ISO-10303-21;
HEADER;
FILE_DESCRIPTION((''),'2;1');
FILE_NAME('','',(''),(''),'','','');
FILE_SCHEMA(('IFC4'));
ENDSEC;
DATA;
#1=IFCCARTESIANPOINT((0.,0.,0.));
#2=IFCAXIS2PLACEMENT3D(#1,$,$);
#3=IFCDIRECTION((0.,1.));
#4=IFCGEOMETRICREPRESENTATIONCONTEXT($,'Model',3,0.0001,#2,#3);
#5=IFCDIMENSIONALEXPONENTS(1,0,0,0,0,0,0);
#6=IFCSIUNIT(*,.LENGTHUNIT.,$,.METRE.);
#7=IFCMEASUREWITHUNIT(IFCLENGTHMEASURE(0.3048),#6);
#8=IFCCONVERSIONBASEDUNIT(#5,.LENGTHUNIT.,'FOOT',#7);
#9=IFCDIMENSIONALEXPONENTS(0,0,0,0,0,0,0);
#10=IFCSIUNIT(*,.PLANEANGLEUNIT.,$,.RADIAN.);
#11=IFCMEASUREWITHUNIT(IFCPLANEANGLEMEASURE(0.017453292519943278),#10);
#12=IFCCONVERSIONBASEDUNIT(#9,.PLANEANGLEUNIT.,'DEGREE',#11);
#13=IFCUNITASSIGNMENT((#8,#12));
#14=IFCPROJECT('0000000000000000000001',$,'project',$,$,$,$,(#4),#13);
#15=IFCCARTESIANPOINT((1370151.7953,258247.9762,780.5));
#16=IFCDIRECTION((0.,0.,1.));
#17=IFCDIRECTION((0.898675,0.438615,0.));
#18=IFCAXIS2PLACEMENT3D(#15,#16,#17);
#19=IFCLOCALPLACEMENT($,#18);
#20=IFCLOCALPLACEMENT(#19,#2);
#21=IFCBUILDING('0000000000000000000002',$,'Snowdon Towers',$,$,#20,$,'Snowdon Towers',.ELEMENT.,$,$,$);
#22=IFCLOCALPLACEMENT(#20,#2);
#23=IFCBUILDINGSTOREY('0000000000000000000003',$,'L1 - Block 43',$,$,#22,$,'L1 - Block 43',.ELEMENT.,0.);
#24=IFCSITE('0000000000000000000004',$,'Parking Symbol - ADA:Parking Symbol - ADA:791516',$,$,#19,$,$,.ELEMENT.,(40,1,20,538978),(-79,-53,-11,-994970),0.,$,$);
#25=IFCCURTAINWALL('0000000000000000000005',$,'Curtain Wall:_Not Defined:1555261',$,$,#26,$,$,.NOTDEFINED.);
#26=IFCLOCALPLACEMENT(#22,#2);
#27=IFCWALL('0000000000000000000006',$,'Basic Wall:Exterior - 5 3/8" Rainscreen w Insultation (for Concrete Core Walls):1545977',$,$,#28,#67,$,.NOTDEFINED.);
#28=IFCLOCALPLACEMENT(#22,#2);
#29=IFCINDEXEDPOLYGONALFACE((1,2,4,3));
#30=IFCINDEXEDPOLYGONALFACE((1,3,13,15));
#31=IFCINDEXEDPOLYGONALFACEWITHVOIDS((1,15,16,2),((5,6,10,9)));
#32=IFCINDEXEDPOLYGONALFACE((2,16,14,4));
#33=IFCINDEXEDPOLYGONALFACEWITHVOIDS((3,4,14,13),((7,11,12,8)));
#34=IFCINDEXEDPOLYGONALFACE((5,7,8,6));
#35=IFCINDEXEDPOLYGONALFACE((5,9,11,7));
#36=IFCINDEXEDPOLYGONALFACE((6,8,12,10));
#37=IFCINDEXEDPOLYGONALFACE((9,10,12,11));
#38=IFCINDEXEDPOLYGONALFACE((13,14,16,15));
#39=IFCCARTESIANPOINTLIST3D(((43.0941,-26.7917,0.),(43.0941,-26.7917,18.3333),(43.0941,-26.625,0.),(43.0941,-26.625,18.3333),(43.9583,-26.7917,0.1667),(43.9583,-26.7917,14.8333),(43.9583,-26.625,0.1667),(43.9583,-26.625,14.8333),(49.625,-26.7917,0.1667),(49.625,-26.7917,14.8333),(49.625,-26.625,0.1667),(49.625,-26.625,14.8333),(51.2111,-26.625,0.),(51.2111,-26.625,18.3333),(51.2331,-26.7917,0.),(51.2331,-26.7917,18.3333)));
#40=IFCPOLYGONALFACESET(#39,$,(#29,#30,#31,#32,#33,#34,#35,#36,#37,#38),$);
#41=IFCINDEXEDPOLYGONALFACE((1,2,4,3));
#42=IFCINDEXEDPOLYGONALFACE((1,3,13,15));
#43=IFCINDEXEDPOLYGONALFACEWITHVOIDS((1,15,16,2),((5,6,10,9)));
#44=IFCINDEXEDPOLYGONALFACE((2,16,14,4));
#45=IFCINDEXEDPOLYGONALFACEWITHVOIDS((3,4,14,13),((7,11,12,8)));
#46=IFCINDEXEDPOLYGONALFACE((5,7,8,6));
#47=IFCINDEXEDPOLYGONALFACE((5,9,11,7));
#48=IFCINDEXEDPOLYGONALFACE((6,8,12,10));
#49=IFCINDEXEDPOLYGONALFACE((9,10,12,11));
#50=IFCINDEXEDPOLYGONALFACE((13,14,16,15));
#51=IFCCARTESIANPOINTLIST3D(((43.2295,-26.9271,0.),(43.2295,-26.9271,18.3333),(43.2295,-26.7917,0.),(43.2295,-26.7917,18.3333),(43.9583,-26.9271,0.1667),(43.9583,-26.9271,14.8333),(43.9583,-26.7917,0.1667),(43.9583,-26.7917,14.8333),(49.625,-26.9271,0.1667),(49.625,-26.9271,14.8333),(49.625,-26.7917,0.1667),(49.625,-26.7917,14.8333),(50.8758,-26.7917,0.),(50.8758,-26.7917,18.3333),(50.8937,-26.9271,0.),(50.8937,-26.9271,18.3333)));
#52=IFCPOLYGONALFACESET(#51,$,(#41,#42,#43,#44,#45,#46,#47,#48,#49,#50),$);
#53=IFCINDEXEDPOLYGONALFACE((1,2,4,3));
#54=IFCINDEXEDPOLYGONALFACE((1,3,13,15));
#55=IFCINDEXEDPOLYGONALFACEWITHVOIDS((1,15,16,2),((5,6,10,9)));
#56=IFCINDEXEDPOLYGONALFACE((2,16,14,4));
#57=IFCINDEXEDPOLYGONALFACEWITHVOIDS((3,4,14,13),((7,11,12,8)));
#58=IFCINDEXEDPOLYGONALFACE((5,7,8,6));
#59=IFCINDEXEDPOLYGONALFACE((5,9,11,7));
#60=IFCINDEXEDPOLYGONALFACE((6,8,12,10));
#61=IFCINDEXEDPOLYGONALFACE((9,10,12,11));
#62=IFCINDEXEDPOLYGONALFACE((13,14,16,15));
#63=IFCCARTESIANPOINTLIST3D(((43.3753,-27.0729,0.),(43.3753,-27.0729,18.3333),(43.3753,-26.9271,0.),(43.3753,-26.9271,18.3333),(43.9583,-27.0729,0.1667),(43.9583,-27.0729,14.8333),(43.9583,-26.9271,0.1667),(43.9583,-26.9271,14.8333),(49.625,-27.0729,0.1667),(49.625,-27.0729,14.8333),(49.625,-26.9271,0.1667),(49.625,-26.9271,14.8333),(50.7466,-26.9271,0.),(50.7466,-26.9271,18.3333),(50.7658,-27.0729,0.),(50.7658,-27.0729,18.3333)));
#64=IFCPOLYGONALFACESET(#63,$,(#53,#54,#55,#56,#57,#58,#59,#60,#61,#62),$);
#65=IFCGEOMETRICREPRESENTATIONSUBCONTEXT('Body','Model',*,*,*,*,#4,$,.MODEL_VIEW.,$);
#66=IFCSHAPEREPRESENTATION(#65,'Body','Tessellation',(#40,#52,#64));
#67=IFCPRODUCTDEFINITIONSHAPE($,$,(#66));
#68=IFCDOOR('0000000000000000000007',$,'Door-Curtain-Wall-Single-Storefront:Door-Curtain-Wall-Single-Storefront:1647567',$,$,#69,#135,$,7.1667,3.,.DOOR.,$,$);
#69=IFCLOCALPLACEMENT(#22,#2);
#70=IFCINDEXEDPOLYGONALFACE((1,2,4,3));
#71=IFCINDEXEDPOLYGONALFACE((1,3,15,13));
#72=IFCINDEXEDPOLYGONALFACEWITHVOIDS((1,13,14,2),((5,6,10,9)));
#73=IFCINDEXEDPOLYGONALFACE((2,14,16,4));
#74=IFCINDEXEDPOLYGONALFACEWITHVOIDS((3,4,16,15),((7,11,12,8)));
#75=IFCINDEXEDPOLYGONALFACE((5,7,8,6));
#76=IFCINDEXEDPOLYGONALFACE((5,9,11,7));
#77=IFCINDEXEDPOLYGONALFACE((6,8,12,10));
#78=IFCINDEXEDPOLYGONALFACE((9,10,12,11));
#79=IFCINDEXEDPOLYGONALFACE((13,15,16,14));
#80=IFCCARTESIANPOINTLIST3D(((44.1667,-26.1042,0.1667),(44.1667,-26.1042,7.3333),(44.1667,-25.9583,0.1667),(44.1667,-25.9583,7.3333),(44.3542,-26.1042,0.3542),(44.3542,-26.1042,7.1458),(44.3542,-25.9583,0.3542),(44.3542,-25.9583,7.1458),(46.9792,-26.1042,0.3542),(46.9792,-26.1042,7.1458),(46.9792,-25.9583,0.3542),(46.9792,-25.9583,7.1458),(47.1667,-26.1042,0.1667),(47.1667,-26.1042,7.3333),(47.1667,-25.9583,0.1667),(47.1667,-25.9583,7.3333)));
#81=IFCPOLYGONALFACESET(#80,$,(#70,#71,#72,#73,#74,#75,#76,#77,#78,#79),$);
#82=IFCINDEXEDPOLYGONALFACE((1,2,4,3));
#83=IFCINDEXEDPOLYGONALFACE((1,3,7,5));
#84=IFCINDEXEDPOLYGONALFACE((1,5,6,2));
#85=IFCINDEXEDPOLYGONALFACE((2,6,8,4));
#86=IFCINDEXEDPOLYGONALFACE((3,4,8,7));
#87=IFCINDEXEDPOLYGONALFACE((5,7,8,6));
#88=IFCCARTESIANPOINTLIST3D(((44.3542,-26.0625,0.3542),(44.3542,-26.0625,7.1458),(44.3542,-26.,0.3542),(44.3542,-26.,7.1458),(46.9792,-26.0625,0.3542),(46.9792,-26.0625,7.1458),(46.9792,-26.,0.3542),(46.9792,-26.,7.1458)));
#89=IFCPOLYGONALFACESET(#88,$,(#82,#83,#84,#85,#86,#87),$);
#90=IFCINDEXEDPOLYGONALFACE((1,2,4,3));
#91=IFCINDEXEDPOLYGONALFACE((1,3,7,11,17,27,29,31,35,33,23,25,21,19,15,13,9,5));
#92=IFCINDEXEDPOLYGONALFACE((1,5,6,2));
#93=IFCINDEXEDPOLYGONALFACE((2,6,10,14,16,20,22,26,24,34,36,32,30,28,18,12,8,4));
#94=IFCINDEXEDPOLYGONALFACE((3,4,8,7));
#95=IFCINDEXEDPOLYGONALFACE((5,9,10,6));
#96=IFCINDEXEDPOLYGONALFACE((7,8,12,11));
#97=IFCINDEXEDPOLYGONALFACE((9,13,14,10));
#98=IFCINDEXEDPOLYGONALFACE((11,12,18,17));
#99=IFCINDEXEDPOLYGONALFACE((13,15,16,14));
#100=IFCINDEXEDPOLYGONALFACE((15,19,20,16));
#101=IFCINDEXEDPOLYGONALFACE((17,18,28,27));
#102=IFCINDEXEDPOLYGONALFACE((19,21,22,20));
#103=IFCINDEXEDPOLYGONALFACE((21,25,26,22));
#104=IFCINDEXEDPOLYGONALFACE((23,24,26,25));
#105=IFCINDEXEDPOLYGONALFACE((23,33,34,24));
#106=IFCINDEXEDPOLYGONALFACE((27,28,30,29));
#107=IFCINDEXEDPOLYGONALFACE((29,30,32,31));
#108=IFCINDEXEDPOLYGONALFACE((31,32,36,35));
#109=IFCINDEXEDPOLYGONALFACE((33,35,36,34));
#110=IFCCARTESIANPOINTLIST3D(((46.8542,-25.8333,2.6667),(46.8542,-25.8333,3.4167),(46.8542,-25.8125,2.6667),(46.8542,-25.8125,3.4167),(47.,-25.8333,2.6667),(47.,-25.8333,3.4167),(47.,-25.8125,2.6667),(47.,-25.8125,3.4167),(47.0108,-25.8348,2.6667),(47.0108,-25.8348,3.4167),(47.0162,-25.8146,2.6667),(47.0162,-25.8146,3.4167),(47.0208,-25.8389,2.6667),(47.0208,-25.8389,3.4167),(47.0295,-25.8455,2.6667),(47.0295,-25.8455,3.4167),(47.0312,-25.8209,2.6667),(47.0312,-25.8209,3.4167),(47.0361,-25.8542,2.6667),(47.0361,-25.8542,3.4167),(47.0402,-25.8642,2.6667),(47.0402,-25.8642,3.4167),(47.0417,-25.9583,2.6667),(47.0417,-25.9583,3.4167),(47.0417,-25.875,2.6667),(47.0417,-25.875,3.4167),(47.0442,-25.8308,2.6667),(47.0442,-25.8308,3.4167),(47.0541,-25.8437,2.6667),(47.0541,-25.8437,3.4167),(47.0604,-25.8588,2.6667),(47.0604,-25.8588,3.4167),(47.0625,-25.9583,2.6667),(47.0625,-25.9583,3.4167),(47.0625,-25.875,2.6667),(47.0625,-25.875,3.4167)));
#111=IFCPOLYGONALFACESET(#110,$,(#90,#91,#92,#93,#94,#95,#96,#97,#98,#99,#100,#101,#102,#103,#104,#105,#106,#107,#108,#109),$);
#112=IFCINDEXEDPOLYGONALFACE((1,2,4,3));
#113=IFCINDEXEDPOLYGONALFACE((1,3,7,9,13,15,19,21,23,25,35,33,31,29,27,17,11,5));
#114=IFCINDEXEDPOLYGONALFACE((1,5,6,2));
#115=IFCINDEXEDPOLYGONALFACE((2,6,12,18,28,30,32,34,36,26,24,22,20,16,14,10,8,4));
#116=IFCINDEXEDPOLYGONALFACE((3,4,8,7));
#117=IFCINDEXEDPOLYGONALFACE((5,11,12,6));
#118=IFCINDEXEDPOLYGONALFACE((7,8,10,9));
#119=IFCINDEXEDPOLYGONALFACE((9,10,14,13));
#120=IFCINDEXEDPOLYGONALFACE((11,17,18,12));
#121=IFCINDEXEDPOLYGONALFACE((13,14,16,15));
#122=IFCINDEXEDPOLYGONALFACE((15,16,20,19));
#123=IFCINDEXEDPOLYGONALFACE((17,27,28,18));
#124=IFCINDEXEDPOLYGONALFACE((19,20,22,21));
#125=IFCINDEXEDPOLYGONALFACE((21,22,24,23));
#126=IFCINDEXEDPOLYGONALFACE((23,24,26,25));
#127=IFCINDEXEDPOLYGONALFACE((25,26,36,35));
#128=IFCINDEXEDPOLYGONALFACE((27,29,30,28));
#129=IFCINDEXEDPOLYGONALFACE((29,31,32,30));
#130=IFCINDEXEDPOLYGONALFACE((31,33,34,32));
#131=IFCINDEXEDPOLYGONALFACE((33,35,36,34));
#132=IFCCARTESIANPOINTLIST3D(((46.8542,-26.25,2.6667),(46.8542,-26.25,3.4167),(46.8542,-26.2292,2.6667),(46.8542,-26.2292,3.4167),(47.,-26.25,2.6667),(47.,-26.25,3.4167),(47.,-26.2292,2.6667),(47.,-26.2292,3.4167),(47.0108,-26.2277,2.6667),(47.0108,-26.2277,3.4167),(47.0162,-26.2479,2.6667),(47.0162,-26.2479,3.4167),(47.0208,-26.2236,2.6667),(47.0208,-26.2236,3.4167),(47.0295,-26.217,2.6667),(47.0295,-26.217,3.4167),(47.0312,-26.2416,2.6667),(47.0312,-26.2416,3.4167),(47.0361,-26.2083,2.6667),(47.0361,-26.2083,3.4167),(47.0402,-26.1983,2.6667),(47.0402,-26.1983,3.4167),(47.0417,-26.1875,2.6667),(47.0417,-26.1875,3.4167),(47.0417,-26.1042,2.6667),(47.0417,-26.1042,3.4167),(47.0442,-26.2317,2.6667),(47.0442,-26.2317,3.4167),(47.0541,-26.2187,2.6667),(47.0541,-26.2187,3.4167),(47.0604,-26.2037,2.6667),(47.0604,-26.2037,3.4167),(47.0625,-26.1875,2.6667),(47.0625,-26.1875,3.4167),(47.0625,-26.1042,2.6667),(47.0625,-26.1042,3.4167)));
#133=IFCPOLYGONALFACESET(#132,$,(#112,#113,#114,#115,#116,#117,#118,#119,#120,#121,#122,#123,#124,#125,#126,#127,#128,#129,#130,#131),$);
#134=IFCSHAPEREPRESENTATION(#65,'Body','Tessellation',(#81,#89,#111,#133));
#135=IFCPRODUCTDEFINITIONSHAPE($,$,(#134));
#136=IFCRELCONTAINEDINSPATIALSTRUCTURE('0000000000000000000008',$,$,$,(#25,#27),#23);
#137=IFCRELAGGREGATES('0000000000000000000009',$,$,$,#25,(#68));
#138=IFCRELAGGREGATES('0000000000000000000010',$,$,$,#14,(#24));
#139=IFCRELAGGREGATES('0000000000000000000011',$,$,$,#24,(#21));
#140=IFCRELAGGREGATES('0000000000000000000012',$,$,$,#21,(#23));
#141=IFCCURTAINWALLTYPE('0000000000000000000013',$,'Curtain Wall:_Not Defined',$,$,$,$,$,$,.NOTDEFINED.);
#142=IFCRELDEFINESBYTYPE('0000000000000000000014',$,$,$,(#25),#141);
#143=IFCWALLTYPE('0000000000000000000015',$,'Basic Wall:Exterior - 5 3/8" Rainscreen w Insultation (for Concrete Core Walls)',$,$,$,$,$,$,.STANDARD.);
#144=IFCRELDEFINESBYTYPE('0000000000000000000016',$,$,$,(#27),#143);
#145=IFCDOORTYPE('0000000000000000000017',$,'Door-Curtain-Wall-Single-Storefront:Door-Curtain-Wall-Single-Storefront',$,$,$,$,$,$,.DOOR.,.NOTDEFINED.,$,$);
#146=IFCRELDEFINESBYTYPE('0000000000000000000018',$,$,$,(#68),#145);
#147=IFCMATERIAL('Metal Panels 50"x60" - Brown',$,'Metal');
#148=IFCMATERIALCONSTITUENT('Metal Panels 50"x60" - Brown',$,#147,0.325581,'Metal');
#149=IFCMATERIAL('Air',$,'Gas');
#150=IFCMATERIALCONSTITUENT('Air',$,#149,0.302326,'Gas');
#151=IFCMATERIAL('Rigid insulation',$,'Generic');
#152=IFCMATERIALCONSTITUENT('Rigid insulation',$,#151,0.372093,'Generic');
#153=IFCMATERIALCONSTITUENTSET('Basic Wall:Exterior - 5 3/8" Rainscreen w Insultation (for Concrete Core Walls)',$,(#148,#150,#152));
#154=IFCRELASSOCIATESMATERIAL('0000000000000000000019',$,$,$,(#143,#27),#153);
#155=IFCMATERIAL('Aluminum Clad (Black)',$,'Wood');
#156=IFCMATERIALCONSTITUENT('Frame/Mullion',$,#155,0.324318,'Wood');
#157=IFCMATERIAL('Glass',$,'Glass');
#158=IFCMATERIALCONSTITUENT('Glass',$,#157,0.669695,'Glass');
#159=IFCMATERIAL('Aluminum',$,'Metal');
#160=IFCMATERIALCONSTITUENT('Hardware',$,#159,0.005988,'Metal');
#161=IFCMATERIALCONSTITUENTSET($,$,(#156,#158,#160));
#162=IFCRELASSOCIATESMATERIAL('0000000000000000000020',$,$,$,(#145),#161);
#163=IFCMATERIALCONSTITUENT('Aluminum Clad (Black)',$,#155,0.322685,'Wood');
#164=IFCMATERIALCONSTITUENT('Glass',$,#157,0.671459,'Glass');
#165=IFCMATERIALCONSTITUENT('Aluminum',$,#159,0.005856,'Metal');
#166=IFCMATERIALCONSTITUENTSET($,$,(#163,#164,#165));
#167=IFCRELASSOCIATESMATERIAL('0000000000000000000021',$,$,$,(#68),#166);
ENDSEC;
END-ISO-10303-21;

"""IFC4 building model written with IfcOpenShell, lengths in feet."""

from ifc_helpers import new_model, entity, si_unit, converted_unit, direction, frame, origin, place, context, subcontext, project, spatial, line, arc, indexed_curve, outline, extrude, source, transform, mapped, material, constituent, constituent_set, type_object, type_shapes, element, aggregate, save


model = new_model("IFC4")

# Units and contexts
model_context = context("Model", 3, precision=0.0001, world=origin(), true_north=direction((0.0, 1.0)))
body_context = subcontext(model_context, "Body", "Model", "MODEL_VIEW")
ifc_project = project(units=[converted_unit("LENGTHUNIT", "FOOT", entity("IfcLengthMeasure", 0.3048), si_unit("LENGTHUNIT", "METRE"), dimensions=[1, 0, 0, 0, 0, 0, 0]), converted_unit("PLANEANGLEUNIT", "DEGREE", entity("IfcPlaneAngleMeasure", 0.017453292519943278), si_unit("PLANEANGLEUNIT", "RADIAN"), dimensions=[0, 0, 0, 0, 0, 0, 0])], contexts=[model_context])

# Site, building, storey
site_placement = place(None, frame((1370151.7953, 258247.9762, 780.5), z_axis=(0.0, 0.0, 1.0), x_axis=(0.898675, 0.438615, 0.0)))
site = spatial("IfcSite", under=ifc_project, at=site_placement, Name="Parking Symbol - ADA:Parking Symbol - ADA:791516", CompositionType="ELEMENT", RefLatitude=(40, 1, 20, 538978), RefLongitude=(-79, -53, -11, -994970), RefElevation=0.0)
building_placement = place(site_placement, origin())
building = spatial("IfcBuilding", under=site, at=building_placement, Name="Snowdon Towers", LongName="Snowdon Towers", CompositionType="ELEMENT")
storey_placement = place(building_placement, origin())
storey = spatial("IfcBuildingStorey", under=building, at=storey_placement, Name="L1 - Block 43", LongName="L1 - Block 43", CompositionType="ELEMENT", Elevation=0.0)

# Curtain wall
curtain_wall_type = type_object("IfcCurtainWallType", Name="Curtain Wall:_Not Defined", PredefinedType="NOTDEFINED")
curtain_wall_1_placement = place(storey_placement, origin())
curtain_wall_1 = element("IfcCurtainWall", 1, at=curtain_wall_1_placement, inside=storey, type_object=curtain_wall_type, Name="Curtain Wall:_Not Defined:1555261", PredefinedType="NOTDEFINED")
ifc_material_1 = material(Name="Aluminum", Category="Metal")

# Shared definitions
ifc_material_2 = material(Name="Glass", Category="Glass")

# Wall, openings
ifc_material_3 = material(Name="Metal Panels 50\"x60\" - Brown", Category="Metal")
ifc_constituent_1 = constituent(ifc_material_3, Name="Metal Panels 50\"x60\" - Brown", Category="Metal", fraction=0.325581)
ifc_material_4 = material(Name="Air", Category="Gas")
ifc_constituent_2 = constituent(ifc_material_4, Name="Air", Category="Gas", fraction=0.302326)
ifc_material_5 = material(Name="Rigid insulation", Category="Generic")
ifc_constituent_3 = constituent(ifc_material_5, Name="Rigid insulation", Category="Generic", fraction=0.372093)
ifc_constituent_set_1 = constituent_set(constituents=[ifc_constituent_1, ifc_constituent_2, ifc_constituent_3], Name="Basic Wall:Exterior - 5 3/8\" Rainscreen w Insultation (for Concrete Core Walls)")
wall_type_1 = type_object("IfcWallType", Name="Basic Wall:Exterior - 5 3/8\" Rainscreen w Insultation (for Concrete Core Walls)", PredefinedType="STANDARD", material=ifc_constituent_set_1)
wall_1_placement = place(storey_placement, frame((43.3753, -26.849, 0.0)))
wall_1 = element("IfcWall", 2, at=wall_1_placement, inside=storey, type_object=wall_type_1, material=ifc_constituent_set_1, Name="Basic Wall:Exterior - 5 3/8\" Rainscreen w Insultation (for Concrete Core Walls):1545977", PredefinedType="NOTDEFINED", context=body_context, shape_type="SweptSolid", body=[
    extrude(outline(indexed_curve([(-0.0833, -4.064), (0.0833, -4.064), (0.0833, 4.075), (-0.0833, 4.053), (-0.0833, -4.064)], self_intersect=False)), frame((3.7828, 0.1406, 0.0), z_axis=(0.0, 0.0, 1.0), x_axis=(0.0, -1.0, 0.0)), (0.0, 0.0, 1.0), 18.3333),
    extrude(outline(indexed_curve([(-0.0677, -3.8276), (0.0677, -3.8276), (0.0677, 3.8365), (-0.0677, 3.8187), (-0.0677, -3.8276)], self_intersect=False)), frame((3.6818, -0.0104, 0.0), z_axis=(0.0, 0.0, 1.0), x_axis=(0.0, -1.0, 0.0)), (0.0, 0.0, 1.0), 18.3333),
    extrude(outline(indexed_curve([(-0.0729, -3.6904), (0.0729, -3.6904), (0.0729, 3.7), (-0.0729, 3.6808), (-0.0729, -3.6904)], self_intersect=False)), frame((3.6904, -0.151, 0.0), z_axis=(0.0, 0.0, 1.0), x_axis=(0.0, -1.0, 0.0)), (0.0, 0.0, 1.0), 18.3333),
])
opening_1_placement = place(storey_placement, frame((43.3753, -26.849, 0.0)))
element("IfcOpeningElement", 3, at=opening_1_placement, cuts=wall_1, PredefinedType="OPENING", context=body_context, shape_type="SweptSolid", body=[
    extrude(outline(indexed_curve([(-7.3333, -2.8333), (7.3333, -2.8333), (7.3333, 2.8333), (-7.3333, 2.8333), (-7.3333, -2.8333)], self_intersect=False)), frame((3.4164, -0.224, 7.5), z_axis=(0.0, 1.0, 0.0), x_axis=(0.0, 0.0, -1.0)), (0.0, 0.0, 1.0), 0.1458),
])
opening_2_placement = place(storey_placement, frame((43.3753, -26.849, 0.0)))
element("IfcOpeningElement", 4, at=opening_2_placement, cuts=wall_1, PredefinedType="OPENING", context=body_context, shape_type="SweptSolid", body=[
    extrude(outline(indexed_curve([(-7.3333, -2.8333), (7.3333, -2.8333), (7.3333, 2.8333), (-7.3333, 2.8333), (-7.3333, -2.8333)], self_intersect=False)), frame((3.4164, -0.0781, 7.5), z_axis=(0.0, 1.0, 0.0), x_axis=(0.0, 0.0, -1.0)), (0.0, 0.0, 1.0), 0.1354),
])
opening_3_placement = place(storey_placement, frame((43.3753, -26.849, 0.0)))
element("IfcOpeningElement", 5, at=opening_3_placement, cuts=wall_1, PredefinedType="OPENING", context=body_context, shape_type="SweptSolid", body=[
    extrude(outline(indexed_curve([(-7.3333, -2.8333), (7.3333, -2.8333), (7.3333, 2.8333), (-7.3333, 2.8333), (-7.3333, -2.8333)], self_intersect=False)), frame((3.4164, 0.224, 7.5), z_axis=(0.0, -1.0, 0.0), x_axis=(0.0, 0.0, 1.0)), (0.0, 0.0, 1.0), 0.1667),
])
opening_4_placement = place(wall_1_placement, origin())
element("IfcOpeningElement", 6, at=opening_4_placement, cuts=wall_1, PredefinedType="OPENING", context=body_context, shape_type="SweptSolid", body=[
    extrude(outline(indexed_curve([(-2.8333, -7.3333), (2.8333, -7.3333), (2.8333, 7.3333), (-2.8333, 7.3333), (-2.8333, -7.3333)], self_intersect=False)), frame((3.4164, -0.724, 7.5), z_axis=(0.0, 1.0, 0.0), x_axis=(-1.0, 0.0, 0.0)), (0.0, 0.0, 1.0), 1.4479),
])

# Door
ifc_material_6 = material(Name="Aluminum Clad (Black)", Category="Wood")
ifc_constituent_4 = constituent(ifc_material_6, Name="Aluminum Clad (Black)", Category="Wood", fraction=0.322685)
ifc_constituent_5 = constituent(ifc_material_2, Name="Glass", Category="Glass", fraction=0.671459)
ifc_constituent_6 = constituent(ifc_material_1, Name="Aluminum", Category="Metal", fraction=0.005856)
ifc_constituent_set_2 = constituent_set(constituents=[ifc_constituent_4, ifc_constituent_5, ifc_constituent_6])
ifc_constituent_7 = constituent(ifc_material_6, Name="Frame/Mullion", Category="Wood", fraction=0.324318)
ifc_constituent_8 = constituent(ifc_material_2, Name="Glass", Category="Glass", fraction=0.669695)
ifc_constituent_9 = constituent(ifc_material_1, Name="Hardware", Category="Metal", fraction=0.005988)
ifc_constituent_set_3 = constituent_set(constituents=[ifc_constituent_7, ifc_constituent_8, ifc_constituent_9])
door_type = type_object("IfcDoorType", Name="Door-Curtain-Wall-Single-Storefront:Door-Curtain-Wall-Single-Storefront", OperationType="NOTDEFINED", PredefinedType="DOOR", material=ifc_constituent_set_3)
shared_shape_1 = source(origin(), body_context, "Body", "SweptSolid", [
    extrude(outline(indexed_curve([(-3.5833, -1.5), (3.5833, -1.5), (3.5833, 1.5), (-3.5833, 1.5), (-3.5833, -1.5)], self_intersect=False), holes=[indexed_curve([(-3.3958, 1.3125), (3.3958, 1.3125), (3.3958, -1.3125), (-3.3958, -1.3125), (-3.3958, 1.3125)], self_intersect=False)]), frame((0.0, 0.1875, 3.5833), z_axis=(0.0, -1.0, 0.0), x_axis=(0.0, 0.0, -1.0)), (0.0, 0.0, 1.0), 0.1458),
    extrude(outline(indexed_curve([(-1.3125, -0.0312), (1.3125, -0.0312), (1.3125, 0.0312), (-1.3125, 0.0312), (-1.3125, -0.0312)], self_intersect=False)), frame((0.0, 0.1146, 0.1875)), (0.0, 0.0, 1.0), 6.7917),
    extrude(outline(indexed_curve([(0.0729, -0.0052), (0.0546, 0.039), (0.0104, 0.0573), (-0.1354, 0.0573), (-0.1354, 0.0365), (0.0104, 0.0365), (0.0399, 0.0243), (0.0521, -0.0052), (0.0521, -0.0885), (0.0729, -0.0885)], segments=[arc(1, 2, 3), line(3, 4, 5, 6), arc(6, 7, 8), line(8, 9, 10, 1)], self_intersect=False)), frame((-1.3229, -0.0469, 2.5), z_axis=(0.0, 0.0, 1.0), x_axis=(-1.0, 0.0, 0.0)), (0.0, 0.0, 1.0), 0.75),
    extrude(outline(indexed_curve([(0.0052, -0.0729), (0.0885, -0.0729), (0.0885, -0.0521), (0.0052, -0.0521), (-0.0243, -0.0399), (-0.0365, -0.0104), (-0.0365, 0.1354), (-0.0573, 0.1354), (-0.0573, -0.0104), (-0.039, -0.0546)], segments=[line(1, 2, 3, 4), arc(4, 5, 6), line(6, 7, 8, 9), arc(9, 10, 1)], self_intersect=False)), frame((-1.3229, 0.276, 2.5), z_axis=(0.0, 0.0, 1.0), x_axis=(0.0, -1.0, 0.0)), (0.0, 0.0, 1.0), 0.75),
])
type_shapes(door_type, [shared_shape_1])
door_placement = place(curtain_wall_1_placement, frame((45.6667, -25.9167, 0.1667), z_axis=(0.0, 0.0, 1.0), x_axis=(-1.0, 0.0, 0.0)))
door = element("IfcDoor", 7, at=door_placement, type_object=door_type, material=ifc_constituent_set_2, Name="Door-Curtain-Wall-Single-Storefront:Door-Curtain-Wall-Single-Storefront:1647567", OverallHeight=7.1667, OverallWidth=3.0, PredefinedType="DOOR", context=body_context, shape_type="MappedRepresentation", body=[
    mapped(shared_shape_1, transform((0.0, 0.0, 0.0), scale=1.0)),
])
aggregate(curtain_wall_1, [door])

save(model, "model.ifc")
